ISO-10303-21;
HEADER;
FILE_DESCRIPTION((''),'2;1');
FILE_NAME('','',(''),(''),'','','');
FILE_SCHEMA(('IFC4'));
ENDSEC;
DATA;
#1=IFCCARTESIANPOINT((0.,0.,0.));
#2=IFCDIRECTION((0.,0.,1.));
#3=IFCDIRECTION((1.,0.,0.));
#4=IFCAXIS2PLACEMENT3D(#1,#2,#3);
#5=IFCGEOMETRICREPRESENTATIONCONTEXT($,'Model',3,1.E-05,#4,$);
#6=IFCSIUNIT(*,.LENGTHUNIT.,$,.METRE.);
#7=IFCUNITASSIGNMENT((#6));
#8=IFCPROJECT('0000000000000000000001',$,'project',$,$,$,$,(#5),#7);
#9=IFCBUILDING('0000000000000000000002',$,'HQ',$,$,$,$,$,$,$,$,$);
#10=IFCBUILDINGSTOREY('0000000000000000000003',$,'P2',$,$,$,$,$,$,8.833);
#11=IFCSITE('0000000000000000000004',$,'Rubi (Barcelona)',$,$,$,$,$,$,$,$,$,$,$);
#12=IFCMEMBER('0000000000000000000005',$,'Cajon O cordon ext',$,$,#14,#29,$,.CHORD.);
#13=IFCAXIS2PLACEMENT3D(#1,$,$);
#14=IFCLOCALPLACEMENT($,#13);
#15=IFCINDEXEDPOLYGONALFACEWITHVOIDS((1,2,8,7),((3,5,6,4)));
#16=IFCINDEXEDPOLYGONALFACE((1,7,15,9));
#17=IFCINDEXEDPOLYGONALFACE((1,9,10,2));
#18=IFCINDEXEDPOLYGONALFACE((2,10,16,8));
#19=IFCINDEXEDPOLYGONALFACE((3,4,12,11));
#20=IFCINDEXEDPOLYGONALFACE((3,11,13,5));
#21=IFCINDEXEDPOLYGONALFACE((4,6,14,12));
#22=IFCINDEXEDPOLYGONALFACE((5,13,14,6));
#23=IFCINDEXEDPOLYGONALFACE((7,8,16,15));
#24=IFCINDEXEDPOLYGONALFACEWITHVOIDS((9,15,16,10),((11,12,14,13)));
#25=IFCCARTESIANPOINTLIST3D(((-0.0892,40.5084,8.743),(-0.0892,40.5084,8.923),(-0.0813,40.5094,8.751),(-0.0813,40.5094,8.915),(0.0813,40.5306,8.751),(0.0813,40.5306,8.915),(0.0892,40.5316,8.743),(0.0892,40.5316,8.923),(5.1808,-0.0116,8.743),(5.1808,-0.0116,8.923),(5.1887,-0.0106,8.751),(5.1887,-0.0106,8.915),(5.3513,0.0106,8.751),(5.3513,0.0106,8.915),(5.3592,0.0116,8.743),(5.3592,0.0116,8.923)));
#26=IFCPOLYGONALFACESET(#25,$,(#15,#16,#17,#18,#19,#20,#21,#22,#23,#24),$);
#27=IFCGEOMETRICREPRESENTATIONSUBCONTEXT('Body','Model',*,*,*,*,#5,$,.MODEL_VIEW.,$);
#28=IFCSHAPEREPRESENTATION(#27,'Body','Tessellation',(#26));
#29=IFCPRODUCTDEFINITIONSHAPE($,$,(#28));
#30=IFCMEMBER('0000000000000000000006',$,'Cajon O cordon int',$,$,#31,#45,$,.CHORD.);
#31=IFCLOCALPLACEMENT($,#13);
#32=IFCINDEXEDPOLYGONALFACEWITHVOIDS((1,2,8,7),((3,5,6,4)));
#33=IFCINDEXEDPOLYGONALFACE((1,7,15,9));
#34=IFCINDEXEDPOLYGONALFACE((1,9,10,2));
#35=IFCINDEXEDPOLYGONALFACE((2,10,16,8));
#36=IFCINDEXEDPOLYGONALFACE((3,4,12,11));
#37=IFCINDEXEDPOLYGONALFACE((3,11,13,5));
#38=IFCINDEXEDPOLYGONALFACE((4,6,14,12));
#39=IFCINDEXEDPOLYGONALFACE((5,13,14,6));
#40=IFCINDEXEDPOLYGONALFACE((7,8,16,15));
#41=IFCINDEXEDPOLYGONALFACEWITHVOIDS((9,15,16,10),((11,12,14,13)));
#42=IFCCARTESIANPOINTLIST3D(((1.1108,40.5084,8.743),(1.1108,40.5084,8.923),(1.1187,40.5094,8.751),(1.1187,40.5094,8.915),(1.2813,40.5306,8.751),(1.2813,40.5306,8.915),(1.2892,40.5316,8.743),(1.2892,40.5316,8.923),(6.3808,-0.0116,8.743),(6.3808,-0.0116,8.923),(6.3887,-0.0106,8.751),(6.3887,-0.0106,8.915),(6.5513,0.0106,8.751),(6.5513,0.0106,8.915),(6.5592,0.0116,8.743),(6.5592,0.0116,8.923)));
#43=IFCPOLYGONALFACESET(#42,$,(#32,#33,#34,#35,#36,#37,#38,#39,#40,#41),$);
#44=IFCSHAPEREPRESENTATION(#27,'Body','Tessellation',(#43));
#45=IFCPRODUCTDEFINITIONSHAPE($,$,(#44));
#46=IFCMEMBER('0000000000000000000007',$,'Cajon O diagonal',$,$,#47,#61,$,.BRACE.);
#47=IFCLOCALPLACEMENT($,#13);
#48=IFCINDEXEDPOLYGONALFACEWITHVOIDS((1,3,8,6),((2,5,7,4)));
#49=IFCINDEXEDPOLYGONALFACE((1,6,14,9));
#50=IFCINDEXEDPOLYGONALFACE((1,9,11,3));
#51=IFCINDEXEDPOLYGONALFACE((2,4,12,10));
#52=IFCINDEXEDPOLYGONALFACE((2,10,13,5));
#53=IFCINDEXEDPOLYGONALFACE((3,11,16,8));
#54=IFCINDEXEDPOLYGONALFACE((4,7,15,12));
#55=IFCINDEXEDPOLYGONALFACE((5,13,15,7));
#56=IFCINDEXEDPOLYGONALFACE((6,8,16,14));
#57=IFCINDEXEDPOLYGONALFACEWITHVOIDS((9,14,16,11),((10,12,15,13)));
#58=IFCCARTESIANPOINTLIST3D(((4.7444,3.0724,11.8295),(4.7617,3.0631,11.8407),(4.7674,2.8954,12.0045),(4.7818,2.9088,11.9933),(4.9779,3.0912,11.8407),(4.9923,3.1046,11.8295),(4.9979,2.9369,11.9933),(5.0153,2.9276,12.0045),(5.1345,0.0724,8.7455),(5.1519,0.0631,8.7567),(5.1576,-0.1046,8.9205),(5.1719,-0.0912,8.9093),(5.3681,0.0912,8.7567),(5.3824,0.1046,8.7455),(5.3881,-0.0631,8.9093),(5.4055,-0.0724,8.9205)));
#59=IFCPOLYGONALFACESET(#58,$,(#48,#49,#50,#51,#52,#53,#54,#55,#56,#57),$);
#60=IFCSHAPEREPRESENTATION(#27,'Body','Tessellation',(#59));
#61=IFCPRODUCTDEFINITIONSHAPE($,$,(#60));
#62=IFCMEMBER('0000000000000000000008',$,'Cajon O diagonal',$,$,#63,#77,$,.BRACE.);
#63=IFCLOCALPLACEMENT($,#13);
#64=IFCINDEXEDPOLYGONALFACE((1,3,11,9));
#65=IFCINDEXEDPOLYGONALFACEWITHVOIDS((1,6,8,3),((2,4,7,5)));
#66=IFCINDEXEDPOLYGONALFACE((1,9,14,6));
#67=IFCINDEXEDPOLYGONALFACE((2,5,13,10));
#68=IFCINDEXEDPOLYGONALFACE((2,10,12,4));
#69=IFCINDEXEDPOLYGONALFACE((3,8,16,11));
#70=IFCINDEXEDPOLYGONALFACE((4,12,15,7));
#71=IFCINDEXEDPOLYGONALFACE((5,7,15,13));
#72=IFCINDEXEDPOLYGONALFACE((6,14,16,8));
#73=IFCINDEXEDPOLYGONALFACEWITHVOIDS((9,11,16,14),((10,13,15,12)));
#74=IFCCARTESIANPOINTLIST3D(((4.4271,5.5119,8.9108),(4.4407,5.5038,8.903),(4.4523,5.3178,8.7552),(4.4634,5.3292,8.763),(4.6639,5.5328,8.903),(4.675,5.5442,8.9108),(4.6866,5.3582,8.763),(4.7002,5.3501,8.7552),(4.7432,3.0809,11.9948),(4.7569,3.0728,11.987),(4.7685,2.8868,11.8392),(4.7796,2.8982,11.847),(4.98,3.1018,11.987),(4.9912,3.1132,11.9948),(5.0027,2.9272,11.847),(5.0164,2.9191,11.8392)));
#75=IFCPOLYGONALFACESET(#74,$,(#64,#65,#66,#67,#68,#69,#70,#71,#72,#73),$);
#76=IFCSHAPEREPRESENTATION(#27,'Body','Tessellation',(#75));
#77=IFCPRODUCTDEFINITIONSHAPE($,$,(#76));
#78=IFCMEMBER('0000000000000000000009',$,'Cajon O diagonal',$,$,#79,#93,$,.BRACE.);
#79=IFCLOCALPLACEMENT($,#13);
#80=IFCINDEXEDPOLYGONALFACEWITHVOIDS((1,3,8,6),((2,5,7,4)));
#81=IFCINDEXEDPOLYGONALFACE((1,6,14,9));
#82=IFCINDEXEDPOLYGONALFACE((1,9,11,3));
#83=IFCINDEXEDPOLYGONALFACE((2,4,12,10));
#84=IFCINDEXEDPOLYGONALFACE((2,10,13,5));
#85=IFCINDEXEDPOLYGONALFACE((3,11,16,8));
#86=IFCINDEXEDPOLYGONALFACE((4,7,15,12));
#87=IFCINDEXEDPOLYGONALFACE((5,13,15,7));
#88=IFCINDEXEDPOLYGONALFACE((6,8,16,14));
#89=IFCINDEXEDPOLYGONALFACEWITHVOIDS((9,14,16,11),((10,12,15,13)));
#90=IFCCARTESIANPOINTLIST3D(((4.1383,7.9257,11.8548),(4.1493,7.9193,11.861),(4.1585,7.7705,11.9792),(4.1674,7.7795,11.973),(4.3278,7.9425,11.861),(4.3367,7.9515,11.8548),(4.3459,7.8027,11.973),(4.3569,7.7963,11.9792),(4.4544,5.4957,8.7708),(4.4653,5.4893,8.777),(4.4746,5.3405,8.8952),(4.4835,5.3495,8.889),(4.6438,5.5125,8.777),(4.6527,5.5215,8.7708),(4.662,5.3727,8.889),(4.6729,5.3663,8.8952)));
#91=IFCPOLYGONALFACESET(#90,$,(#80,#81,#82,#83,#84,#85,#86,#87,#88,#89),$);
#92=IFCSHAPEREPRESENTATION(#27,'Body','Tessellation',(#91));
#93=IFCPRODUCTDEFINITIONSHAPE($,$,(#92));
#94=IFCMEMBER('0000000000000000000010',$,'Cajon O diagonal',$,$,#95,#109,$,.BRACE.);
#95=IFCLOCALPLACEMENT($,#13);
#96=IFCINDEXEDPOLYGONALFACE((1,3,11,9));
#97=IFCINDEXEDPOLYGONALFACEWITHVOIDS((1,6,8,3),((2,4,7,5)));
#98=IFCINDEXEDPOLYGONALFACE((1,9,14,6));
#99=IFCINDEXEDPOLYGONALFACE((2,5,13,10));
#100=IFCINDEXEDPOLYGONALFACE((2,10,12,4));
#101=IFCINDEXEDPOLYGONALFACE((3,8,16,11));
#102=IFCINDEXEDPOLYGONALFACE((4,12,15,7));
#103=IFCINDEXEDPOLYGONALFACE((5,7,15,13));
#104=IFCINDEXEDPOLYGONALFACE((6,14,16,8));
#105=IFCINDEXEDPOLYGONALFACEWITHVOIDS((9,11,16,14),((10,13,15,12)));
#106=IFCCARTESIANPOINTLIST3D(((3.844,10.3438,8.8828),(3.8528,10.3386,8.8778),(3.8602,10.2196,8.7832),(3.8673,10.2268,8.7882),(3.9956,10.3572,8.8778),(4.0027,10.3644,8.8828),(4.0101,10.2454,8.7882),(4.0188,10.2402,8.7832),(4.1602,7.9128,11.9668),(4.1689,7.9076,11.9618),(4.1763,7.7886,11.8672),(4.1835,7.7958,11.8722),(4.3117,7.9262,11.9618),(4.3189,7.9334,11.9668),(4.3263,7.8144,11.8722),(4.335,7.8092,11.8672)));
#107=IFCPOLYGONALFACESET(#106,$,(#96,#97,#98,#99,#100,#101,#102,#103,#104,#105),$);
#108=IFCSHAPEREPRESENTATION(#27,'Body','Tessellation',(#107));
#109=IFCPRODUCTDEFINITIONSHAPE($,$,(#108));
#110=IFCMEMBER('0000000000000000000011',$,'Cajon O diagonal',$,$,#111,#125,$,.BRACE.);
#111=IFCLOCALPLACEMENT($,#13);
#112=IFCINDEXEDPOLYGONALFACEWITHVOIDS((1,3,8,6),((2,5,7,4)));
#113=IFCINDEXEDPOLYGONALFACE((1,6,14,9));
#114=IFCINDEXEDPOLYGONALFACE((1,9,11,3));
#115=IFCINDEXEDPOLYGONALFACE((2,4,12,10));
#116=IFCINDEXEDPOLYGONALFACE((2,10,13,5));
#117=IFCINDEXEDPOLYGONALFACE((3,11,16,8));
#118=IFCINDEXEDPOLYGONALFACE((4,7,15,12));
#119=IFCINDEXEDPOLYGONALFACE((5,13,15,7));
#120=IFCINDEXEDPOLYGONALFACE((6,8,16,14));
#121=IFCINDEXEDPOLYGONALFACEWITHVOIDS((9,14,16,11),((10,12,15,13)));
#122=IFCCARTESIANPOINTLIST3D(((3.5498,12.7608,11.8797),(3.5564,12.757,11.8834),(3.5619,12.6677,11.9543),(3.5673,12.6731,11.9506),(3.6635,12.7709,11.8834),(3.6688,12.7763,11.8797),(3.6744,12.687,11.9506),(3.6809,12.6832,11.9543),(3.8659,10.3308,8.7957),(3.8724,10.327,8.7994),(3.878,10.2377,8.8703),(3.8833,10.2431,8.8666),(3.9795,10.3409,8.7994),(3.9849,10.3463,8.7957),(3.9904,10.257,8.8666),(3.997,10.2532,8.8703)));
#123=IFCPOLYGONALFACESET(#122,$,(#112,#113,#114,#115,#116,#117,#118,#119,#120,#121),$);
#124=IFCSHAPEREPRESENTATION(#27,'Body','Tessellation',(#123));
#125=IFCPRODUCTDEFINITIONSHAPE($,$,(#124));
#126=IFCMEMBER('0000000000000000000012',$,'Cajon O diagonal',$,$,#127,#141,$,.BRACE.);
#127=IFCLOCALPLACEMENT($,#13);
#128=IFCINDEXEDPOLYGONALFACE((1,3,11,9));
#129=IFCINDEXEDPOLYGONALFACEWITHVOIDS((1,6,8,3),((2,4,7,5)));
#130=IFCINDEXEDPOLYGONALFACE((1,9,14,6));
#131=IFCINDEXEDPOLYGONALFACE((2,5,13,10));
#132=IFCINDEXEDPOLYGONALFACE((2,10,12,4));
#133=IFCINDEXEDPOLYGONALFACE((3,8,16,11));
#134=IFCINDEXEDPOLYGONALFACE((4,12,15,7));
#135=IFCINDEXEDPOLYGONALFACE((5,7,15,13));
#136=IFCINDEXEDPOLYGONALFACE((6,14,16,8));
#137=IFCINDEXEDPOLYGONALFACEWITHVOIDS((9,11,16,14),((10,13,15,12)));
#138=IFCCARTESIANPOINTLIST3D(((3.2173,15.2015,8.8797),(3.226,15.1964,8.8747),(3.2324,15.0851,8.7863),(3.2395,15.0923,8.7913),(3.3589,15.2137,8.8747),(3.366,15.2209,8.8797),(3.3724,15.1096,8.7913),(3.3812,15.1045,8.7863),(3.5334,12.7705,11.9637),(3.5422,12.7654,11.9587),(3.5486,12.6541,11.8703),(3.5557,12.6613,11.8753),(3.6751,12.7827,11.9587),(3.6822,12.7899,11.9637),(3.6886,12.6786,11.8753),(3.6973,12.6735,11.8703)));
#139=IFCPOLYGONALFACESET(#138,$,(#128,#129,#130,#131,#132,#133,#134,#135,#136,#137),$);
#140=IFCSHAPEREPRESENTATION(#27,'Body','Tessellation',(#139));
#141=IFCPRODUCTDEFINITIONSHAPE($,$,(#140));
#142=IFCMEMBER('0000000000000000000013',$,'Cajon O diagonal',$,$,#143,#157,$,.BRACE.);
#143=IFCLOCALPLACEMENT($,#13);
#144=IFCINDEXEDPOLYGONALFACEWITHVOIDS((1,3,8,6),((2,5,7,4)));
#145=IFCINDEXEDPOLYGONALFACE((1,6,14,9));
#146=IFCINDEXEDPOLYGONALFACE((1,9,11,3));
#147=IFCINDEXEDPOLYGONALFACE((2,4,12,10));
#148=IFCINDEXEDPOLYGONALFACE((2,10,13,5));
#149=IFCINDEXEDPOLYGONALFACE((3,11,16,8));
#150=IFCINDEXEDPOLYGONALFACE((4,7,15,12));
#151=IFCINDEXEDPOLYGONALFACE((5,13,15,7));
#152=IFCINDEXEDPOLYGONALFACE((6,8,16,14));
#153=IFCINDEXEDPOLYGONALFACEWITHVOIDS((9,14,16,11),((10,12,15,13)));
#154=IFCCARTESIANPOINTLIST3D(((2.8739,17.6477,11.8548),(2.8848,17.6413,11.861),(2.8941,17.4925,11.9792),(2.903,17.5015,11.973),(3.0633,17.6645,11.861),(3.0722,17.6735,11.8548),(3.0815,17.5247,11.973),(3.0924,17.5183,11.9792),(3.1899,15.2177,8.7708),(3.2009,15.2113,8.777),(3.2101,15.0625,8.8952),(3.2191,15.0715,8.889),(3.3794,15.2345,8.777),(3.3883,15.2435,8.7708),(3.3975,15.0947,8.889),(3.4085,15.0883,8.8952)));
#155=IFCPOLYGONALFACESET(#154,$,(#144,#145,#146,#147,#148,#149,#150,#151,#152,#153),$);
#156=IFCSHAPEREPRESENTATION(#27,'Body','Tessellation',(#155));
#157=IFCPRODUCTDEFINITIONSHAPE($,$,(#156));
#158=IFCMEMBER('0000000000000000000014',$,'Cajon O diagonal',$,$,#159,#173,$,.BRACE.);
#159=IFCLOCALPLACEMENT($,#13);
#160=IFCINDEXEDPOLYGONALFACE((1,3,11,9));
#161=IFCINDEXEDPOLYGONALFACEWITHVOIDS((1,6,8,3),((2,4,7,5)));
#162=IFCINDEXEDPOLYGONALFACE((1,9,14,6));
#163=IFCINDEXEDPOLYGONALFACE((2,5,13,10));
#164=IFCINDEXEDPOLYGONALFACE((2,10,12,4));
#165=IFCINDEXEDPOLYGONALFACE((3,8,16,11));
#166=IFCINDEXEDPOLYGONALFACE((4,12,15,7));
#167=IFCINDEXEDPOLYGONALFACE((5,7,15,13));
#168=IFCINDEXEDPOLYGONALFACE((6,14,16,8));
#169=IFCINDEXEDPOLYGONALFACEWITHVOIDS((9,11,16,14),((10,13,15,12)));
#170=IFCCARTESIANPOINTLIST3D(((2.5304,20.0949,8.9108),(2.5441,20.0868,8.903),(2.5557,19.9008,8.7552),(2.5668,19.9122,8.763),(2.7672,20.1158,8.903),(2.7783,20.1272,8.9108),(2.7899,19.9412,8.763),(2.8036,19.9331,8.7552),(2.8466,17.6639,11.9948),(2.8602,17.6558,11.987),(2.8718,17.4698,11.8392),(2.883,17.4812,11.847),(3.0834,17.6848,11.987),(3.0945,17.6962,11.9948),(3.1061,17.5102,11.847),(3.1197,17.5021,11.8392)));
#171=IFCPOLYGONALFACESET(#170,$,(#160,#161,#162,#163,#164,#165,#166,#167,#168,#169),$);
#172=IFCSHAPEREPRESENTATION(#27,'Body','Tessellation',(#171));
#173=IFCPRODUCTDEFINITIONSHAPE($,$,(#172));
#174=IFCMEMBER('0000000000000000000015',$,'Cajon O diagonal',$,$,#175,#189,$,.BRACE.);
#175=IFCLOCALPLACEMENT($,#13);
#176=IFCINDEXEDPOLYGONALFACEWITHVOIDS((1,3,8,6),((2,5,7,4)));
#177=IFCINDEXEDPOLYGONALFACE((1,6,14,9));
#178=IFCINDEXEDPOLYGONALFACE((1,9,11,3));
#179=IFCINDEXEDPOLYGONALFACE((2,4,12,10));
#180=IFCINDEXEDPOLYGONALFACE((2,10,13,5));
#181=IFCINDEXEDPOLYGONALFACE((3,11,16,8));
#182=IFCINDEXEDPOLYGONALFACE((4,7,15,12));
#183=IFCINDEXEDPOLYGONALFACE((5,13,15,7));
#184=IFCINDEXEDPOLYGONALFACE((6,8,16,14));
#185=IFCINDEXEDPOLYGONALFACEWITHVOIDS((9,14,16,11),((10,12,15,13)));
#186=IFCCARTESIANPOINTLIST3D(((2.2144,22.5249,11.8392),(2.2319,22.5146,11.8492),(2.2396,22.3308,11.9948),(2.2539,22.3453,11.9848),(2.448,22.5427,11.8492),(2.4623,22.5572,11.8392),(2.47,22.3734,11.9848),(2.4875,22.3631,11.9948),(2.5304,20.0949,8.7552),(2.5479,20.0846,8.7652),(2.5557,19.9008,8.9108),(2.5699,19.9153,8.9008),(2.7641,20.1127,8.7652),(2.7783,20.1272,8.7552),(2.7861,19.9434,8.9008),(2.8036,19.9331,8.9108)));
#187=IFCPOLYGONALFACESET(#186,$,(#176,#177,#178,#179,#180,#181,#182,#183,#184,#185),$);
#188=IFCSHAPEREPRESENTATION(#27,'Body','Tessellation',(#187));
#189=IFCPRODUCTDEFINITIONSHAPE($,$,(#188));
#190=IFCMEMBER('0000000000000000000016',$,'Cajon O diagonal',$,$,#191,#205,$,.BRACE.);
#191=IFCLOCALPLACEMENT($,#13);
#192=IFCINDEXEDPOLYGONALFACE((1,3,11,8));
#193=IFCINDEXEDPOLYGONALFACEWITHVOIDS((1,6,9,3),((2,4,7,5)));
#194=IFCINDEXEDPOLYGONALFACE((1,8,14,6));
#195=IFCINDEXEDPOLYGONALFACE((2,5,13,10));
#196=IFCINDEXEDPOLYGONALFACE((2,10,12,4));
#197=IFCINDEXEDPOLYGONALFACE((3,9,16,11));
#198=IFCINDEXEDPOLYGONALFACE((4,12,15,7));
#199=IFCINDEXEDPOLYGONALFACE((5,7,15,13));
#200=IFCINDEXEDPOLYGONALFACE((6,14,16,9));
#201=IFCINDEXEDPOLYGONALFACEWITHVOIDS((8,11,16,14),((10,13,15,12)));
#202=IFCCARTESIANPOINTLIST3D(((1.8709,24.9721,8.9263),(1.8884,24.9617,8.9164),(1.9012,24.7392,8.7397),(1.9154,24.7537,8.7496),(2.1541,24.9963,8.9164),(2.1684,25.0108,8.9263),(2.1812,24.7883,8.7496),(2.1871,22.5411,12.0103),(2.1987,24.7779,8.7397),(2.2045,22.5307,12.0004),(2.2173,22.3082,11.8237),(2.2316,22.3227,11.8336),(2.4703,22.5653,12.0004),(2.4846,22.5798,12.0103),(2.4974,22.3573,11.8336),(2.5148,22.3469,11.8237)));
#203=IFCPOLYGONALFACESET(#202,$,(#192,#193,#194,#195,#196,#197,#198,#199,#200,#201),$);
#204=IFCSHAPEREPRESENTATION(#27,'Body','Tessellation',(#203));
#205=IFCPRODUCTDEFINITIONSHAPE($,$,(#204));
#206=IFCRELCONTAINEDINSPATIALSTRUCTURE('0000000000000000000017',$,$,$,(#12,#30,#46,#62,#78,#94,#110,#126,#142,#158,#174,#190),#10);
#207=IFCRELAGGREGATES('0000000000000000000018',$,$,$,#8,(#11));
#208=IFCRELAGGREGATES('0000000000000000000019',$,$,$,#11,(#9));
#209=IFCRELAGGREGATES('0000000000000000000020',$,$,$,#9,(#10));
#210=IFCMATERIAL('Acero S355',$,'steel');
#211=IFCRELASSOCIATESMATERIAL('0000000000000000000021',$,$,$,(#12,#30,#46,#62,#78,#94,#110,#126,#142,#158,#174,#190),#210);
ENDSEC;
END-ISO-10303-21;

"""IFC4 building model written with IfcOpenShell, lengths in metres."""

from ifc_helpers import new_model, si_unit, frame, origin_with_axes, place, context, subcontext, project, spatial, hollow_rectangle, extrude, material, element, save


model = new_model("IFC4")

# Units and contexts
model_context = context("Model", 3, precision=1e-05, world=origin_with_axes())
body_context = subcontext(model_context, "Body", "Model", "MODEL_VIEW")
ifc_project = project(units=[si_unit("LENGTHUNIT", "METRE")], contexts=[model_context])

# Site, building, storey
site = spatial("IfcSite", under=ifc_project, Name="Rubi (Barcelona)")
building = spatial("IfcBuilding", under=site, Name="HQ")
storey = spatial("IfcBuildingStorey", under=building, Name="P2", Elevation=8.833)

# Members
ifc_material = material(Name="Acero S355", Category="steel")
member_1_placement = place(None, origin_with_axes())
element("IfcMember", 1, at=member_1_placement, inside=storey, material=ifc_material, Name="Cajon O cordon ext", PredefinedType="CHORD", context=body_context, shape_type="SweptSolid", body=[
    extrude(hollow_rectangle(XDim=0.18, YDim=0.18, WallThickness=0.008), frame((5.27, 0.0, 8.833), z_axis=(-0.128973, 0.991648, 0.0), x_axis=(-0.991648, -0.128973, 0.0)), (0.0, 0.0, 1.0), 40.8613),
])
member_2_placement = place(None, origin_with_axes())
element("IfcMember", 2, at=member_2_placement, inside=storey, material=ifc_material, Name="Cajon O cordon int", PredefinedType="CHORD", context=body_context, shape_type="SweptSolid", body=[
    extrude(hollow_rectangle(XDim=0.18, YDim=0.18, WallThickness=0.008), frame((6.47, 0.0, 8.833), z_axis=(-0.128973, 0.991648, 0.0), x_axis=(-0.991648, -0.128973, 0.0)), (0.0, 0.0, 1.0), 40.8613),
])
member_3_placement = place(None, origin_with_axes())
element("IfcMember", 3, at=member_3_placement, inside=storey, material=ifc_material, Name="Cajon O diagonal", PredefinedType="BRACE", context=body_context, shape_type="SweptSolid", body=[
    extrude(hollow_rectangle(XDim=0.25, YDim=0.25, WallThickness=0.016), frame((5.27, 0.0, 8.833), z_axis=(-0.090317, 0.694428, 0.713872), x_axis=(-0.991648, -0.128973, 0.0)), (0.0, 0.0, 1.0), 4.3201),
])
member_4_placement = place(None, origin_with_axes())
element("IfcMember", 4, at=member_4_placement, inside=storey, material=ifc_material, Name="Cajon O diagonal", PredefinedType="BRACE", context=body_context, shape_type="SweptSolid", body=[
    extrude(hollow_rectangle(XDim=0.25, YDim=0.25, WallThickness=0.0125), frame((4.5636, 5.431, 8.833), z_axis=(0.080254, -0.617061, 0.782812), x_axis=(0.991648, 0.128973, 0.0)), (0.0, 0.0, 1.0), 3.9396),
])
member_5_placement = place(None, origin_with_axes())
element("IfcMember", 5, at=member_5_placement, inside=storey, material=ifc_material, Name="Cajon O diagonal", PredefinedType="BRACE", context=body_context, shape_type="SweptSolid", body=[
    extrude(hollow_rectangle(XDim=0.2, YDim=0.2, WallThickness=0.01), frame((4.5636, 5.431, 8.833), z_axis=(-0.080234, 0.616905, 0.782937), x_axis=(-0.991648, -0.128973, 0.0)), (0.0, 0.0, 1.0), 3.939),
])
member_6_placement = place(None, origin_with_axes())
element("IfcMember", 6, at=member_6_placement, inside=storey, material=ifc_material, Name="Cajon O diagonal", PredefinedType="BRACE", context=body_context, shape_type="SweptSolid", body=[
    extrude(hollow_rectangle(XDim=0.16, YDim=0.16, WallThickness=0.008), frame((3.9314, 10.292, 8.833), z_axis=(0.080254, -0.617061, 0.782812), x_axis=(0.991648, 0.128973, 0.0)), (0.0, 0.0, 1.0), 3.9396),
])
member_7_placement = place(None, origin_with_axes())
element("IfcMember", 7, at=member_7_placement, inside=storey, material=ifc_material, Name="Cajon O diagonal", PredefinedType="BRACE", context=body_context, shape_type="SweptSolid", body=[
    extrude(hollow_rectangle(XDim=0.12, YDim=0.12, WallThickness=0.006), frame((3.9314, 10.292, 8.833), z_axis=(-0.080234, 0.616905, 0.782937), x_axis=(-0.991648, -0.128973, 0.0)), (0.0, 0.0, 1.0), 3.939),
])
member_8_placement = place(None, origin_with_axes())
element("IfcMember", 8, at=member_8_placement, inside=storey, material=ifc_material, Name="Cajon O diagonal", PredefinedType="BRACE", context=body_context, shape_type="SweptSolid", body=[
    extrude(hollow_rectangle(XDim=0.15, YDim=0.15, WallThickness=0.008), frame((3.2992, 15.153, 8.833), z_axis=(0.080254, -0.617061, 0.782812), x_axis=(0.991648, 0.128973, 0.0)), (0.0, 0.0, 1.0), 3.9396),
])
member_9_placement = place(None, origin_with_axes())
element("IfcMember", 9, at=member_9_placement, inside=storey, material=ifc_material, Name="Cajon O diagonal", PredefinedType="BRACE", context=body_context, shape_type="SweptSolid", body=[
    extrude(hollow_rectangle(XDim=0.2, YDim=0.2, WallThickness=0.01), frame((3.2992, 15.153, 8.833), z_axis=(-0.080234, 0.616905, 0.782937), x_axis=(-0.991648, -0.128973, 0.0)), (0.0, 0.0, 1.0), 3.939),
])
member_10_placement = place(None, origin_with_axes())
element("IfcMember", 10, at=member_10_placement, inside=storey, material=ifc_material, Name="Cajon O diagonal", PredefinedType="BRACE", context=body_context, shape_type="SweptSolid", body=[
    extrude(hollow_rectangle(XDim=0.25, YDim=0.25, WallThickness=0.0125), frame((2.667, 20.014, 8.833), z_axis=(0.080254, -0.617061, 0.782812), x_axis=(0.991648, 0.128973, 0.0)), (0.0, 0.0, 1.0), 3.9396),
])
member_11_placement = place(None, origin_with_axes())
element("IfcMember", 11, at=member_11_placement, inside=storey, material=ifc_material, Name="Cajon O diagonal", PredefinedType="BRACE", context=body_context, shape_type="SweptSolid", body=[
    extrude(hollow_rectangle(XDim=0.25, YDim=0.25, WallThickness=0.016), frame((2.667, 20.014, 8.833), z_axis=(-0.080234, 0.616905, 0.782937), x_axis=(-0.991648, -0.128973, 0.0)), (0.0, 0.0, 1.0), 3.939),
])
member_12_placement = place(None, origin_with_axes())
element("IfcMember", 12, at=member_12_placement, inside=storey, material=ifc_material, Name="Cajon O diagonal", PredefinedType="BRACE", context=body_context, shape_type="SweptSolid", body=[
    extrude(hollow_rectangle(XDim=0.3, YDim=0.3, WallThickness=0.016), frame((2.0348, 24.875, 8.833), z_axis=(0.080254, -0.617061, 0.782812), x_axis=(0.991648, 0.128973, 0.0)), (0.0, 0.0, 1.0), 3.9396),
])

save(model, "model.ifc")
